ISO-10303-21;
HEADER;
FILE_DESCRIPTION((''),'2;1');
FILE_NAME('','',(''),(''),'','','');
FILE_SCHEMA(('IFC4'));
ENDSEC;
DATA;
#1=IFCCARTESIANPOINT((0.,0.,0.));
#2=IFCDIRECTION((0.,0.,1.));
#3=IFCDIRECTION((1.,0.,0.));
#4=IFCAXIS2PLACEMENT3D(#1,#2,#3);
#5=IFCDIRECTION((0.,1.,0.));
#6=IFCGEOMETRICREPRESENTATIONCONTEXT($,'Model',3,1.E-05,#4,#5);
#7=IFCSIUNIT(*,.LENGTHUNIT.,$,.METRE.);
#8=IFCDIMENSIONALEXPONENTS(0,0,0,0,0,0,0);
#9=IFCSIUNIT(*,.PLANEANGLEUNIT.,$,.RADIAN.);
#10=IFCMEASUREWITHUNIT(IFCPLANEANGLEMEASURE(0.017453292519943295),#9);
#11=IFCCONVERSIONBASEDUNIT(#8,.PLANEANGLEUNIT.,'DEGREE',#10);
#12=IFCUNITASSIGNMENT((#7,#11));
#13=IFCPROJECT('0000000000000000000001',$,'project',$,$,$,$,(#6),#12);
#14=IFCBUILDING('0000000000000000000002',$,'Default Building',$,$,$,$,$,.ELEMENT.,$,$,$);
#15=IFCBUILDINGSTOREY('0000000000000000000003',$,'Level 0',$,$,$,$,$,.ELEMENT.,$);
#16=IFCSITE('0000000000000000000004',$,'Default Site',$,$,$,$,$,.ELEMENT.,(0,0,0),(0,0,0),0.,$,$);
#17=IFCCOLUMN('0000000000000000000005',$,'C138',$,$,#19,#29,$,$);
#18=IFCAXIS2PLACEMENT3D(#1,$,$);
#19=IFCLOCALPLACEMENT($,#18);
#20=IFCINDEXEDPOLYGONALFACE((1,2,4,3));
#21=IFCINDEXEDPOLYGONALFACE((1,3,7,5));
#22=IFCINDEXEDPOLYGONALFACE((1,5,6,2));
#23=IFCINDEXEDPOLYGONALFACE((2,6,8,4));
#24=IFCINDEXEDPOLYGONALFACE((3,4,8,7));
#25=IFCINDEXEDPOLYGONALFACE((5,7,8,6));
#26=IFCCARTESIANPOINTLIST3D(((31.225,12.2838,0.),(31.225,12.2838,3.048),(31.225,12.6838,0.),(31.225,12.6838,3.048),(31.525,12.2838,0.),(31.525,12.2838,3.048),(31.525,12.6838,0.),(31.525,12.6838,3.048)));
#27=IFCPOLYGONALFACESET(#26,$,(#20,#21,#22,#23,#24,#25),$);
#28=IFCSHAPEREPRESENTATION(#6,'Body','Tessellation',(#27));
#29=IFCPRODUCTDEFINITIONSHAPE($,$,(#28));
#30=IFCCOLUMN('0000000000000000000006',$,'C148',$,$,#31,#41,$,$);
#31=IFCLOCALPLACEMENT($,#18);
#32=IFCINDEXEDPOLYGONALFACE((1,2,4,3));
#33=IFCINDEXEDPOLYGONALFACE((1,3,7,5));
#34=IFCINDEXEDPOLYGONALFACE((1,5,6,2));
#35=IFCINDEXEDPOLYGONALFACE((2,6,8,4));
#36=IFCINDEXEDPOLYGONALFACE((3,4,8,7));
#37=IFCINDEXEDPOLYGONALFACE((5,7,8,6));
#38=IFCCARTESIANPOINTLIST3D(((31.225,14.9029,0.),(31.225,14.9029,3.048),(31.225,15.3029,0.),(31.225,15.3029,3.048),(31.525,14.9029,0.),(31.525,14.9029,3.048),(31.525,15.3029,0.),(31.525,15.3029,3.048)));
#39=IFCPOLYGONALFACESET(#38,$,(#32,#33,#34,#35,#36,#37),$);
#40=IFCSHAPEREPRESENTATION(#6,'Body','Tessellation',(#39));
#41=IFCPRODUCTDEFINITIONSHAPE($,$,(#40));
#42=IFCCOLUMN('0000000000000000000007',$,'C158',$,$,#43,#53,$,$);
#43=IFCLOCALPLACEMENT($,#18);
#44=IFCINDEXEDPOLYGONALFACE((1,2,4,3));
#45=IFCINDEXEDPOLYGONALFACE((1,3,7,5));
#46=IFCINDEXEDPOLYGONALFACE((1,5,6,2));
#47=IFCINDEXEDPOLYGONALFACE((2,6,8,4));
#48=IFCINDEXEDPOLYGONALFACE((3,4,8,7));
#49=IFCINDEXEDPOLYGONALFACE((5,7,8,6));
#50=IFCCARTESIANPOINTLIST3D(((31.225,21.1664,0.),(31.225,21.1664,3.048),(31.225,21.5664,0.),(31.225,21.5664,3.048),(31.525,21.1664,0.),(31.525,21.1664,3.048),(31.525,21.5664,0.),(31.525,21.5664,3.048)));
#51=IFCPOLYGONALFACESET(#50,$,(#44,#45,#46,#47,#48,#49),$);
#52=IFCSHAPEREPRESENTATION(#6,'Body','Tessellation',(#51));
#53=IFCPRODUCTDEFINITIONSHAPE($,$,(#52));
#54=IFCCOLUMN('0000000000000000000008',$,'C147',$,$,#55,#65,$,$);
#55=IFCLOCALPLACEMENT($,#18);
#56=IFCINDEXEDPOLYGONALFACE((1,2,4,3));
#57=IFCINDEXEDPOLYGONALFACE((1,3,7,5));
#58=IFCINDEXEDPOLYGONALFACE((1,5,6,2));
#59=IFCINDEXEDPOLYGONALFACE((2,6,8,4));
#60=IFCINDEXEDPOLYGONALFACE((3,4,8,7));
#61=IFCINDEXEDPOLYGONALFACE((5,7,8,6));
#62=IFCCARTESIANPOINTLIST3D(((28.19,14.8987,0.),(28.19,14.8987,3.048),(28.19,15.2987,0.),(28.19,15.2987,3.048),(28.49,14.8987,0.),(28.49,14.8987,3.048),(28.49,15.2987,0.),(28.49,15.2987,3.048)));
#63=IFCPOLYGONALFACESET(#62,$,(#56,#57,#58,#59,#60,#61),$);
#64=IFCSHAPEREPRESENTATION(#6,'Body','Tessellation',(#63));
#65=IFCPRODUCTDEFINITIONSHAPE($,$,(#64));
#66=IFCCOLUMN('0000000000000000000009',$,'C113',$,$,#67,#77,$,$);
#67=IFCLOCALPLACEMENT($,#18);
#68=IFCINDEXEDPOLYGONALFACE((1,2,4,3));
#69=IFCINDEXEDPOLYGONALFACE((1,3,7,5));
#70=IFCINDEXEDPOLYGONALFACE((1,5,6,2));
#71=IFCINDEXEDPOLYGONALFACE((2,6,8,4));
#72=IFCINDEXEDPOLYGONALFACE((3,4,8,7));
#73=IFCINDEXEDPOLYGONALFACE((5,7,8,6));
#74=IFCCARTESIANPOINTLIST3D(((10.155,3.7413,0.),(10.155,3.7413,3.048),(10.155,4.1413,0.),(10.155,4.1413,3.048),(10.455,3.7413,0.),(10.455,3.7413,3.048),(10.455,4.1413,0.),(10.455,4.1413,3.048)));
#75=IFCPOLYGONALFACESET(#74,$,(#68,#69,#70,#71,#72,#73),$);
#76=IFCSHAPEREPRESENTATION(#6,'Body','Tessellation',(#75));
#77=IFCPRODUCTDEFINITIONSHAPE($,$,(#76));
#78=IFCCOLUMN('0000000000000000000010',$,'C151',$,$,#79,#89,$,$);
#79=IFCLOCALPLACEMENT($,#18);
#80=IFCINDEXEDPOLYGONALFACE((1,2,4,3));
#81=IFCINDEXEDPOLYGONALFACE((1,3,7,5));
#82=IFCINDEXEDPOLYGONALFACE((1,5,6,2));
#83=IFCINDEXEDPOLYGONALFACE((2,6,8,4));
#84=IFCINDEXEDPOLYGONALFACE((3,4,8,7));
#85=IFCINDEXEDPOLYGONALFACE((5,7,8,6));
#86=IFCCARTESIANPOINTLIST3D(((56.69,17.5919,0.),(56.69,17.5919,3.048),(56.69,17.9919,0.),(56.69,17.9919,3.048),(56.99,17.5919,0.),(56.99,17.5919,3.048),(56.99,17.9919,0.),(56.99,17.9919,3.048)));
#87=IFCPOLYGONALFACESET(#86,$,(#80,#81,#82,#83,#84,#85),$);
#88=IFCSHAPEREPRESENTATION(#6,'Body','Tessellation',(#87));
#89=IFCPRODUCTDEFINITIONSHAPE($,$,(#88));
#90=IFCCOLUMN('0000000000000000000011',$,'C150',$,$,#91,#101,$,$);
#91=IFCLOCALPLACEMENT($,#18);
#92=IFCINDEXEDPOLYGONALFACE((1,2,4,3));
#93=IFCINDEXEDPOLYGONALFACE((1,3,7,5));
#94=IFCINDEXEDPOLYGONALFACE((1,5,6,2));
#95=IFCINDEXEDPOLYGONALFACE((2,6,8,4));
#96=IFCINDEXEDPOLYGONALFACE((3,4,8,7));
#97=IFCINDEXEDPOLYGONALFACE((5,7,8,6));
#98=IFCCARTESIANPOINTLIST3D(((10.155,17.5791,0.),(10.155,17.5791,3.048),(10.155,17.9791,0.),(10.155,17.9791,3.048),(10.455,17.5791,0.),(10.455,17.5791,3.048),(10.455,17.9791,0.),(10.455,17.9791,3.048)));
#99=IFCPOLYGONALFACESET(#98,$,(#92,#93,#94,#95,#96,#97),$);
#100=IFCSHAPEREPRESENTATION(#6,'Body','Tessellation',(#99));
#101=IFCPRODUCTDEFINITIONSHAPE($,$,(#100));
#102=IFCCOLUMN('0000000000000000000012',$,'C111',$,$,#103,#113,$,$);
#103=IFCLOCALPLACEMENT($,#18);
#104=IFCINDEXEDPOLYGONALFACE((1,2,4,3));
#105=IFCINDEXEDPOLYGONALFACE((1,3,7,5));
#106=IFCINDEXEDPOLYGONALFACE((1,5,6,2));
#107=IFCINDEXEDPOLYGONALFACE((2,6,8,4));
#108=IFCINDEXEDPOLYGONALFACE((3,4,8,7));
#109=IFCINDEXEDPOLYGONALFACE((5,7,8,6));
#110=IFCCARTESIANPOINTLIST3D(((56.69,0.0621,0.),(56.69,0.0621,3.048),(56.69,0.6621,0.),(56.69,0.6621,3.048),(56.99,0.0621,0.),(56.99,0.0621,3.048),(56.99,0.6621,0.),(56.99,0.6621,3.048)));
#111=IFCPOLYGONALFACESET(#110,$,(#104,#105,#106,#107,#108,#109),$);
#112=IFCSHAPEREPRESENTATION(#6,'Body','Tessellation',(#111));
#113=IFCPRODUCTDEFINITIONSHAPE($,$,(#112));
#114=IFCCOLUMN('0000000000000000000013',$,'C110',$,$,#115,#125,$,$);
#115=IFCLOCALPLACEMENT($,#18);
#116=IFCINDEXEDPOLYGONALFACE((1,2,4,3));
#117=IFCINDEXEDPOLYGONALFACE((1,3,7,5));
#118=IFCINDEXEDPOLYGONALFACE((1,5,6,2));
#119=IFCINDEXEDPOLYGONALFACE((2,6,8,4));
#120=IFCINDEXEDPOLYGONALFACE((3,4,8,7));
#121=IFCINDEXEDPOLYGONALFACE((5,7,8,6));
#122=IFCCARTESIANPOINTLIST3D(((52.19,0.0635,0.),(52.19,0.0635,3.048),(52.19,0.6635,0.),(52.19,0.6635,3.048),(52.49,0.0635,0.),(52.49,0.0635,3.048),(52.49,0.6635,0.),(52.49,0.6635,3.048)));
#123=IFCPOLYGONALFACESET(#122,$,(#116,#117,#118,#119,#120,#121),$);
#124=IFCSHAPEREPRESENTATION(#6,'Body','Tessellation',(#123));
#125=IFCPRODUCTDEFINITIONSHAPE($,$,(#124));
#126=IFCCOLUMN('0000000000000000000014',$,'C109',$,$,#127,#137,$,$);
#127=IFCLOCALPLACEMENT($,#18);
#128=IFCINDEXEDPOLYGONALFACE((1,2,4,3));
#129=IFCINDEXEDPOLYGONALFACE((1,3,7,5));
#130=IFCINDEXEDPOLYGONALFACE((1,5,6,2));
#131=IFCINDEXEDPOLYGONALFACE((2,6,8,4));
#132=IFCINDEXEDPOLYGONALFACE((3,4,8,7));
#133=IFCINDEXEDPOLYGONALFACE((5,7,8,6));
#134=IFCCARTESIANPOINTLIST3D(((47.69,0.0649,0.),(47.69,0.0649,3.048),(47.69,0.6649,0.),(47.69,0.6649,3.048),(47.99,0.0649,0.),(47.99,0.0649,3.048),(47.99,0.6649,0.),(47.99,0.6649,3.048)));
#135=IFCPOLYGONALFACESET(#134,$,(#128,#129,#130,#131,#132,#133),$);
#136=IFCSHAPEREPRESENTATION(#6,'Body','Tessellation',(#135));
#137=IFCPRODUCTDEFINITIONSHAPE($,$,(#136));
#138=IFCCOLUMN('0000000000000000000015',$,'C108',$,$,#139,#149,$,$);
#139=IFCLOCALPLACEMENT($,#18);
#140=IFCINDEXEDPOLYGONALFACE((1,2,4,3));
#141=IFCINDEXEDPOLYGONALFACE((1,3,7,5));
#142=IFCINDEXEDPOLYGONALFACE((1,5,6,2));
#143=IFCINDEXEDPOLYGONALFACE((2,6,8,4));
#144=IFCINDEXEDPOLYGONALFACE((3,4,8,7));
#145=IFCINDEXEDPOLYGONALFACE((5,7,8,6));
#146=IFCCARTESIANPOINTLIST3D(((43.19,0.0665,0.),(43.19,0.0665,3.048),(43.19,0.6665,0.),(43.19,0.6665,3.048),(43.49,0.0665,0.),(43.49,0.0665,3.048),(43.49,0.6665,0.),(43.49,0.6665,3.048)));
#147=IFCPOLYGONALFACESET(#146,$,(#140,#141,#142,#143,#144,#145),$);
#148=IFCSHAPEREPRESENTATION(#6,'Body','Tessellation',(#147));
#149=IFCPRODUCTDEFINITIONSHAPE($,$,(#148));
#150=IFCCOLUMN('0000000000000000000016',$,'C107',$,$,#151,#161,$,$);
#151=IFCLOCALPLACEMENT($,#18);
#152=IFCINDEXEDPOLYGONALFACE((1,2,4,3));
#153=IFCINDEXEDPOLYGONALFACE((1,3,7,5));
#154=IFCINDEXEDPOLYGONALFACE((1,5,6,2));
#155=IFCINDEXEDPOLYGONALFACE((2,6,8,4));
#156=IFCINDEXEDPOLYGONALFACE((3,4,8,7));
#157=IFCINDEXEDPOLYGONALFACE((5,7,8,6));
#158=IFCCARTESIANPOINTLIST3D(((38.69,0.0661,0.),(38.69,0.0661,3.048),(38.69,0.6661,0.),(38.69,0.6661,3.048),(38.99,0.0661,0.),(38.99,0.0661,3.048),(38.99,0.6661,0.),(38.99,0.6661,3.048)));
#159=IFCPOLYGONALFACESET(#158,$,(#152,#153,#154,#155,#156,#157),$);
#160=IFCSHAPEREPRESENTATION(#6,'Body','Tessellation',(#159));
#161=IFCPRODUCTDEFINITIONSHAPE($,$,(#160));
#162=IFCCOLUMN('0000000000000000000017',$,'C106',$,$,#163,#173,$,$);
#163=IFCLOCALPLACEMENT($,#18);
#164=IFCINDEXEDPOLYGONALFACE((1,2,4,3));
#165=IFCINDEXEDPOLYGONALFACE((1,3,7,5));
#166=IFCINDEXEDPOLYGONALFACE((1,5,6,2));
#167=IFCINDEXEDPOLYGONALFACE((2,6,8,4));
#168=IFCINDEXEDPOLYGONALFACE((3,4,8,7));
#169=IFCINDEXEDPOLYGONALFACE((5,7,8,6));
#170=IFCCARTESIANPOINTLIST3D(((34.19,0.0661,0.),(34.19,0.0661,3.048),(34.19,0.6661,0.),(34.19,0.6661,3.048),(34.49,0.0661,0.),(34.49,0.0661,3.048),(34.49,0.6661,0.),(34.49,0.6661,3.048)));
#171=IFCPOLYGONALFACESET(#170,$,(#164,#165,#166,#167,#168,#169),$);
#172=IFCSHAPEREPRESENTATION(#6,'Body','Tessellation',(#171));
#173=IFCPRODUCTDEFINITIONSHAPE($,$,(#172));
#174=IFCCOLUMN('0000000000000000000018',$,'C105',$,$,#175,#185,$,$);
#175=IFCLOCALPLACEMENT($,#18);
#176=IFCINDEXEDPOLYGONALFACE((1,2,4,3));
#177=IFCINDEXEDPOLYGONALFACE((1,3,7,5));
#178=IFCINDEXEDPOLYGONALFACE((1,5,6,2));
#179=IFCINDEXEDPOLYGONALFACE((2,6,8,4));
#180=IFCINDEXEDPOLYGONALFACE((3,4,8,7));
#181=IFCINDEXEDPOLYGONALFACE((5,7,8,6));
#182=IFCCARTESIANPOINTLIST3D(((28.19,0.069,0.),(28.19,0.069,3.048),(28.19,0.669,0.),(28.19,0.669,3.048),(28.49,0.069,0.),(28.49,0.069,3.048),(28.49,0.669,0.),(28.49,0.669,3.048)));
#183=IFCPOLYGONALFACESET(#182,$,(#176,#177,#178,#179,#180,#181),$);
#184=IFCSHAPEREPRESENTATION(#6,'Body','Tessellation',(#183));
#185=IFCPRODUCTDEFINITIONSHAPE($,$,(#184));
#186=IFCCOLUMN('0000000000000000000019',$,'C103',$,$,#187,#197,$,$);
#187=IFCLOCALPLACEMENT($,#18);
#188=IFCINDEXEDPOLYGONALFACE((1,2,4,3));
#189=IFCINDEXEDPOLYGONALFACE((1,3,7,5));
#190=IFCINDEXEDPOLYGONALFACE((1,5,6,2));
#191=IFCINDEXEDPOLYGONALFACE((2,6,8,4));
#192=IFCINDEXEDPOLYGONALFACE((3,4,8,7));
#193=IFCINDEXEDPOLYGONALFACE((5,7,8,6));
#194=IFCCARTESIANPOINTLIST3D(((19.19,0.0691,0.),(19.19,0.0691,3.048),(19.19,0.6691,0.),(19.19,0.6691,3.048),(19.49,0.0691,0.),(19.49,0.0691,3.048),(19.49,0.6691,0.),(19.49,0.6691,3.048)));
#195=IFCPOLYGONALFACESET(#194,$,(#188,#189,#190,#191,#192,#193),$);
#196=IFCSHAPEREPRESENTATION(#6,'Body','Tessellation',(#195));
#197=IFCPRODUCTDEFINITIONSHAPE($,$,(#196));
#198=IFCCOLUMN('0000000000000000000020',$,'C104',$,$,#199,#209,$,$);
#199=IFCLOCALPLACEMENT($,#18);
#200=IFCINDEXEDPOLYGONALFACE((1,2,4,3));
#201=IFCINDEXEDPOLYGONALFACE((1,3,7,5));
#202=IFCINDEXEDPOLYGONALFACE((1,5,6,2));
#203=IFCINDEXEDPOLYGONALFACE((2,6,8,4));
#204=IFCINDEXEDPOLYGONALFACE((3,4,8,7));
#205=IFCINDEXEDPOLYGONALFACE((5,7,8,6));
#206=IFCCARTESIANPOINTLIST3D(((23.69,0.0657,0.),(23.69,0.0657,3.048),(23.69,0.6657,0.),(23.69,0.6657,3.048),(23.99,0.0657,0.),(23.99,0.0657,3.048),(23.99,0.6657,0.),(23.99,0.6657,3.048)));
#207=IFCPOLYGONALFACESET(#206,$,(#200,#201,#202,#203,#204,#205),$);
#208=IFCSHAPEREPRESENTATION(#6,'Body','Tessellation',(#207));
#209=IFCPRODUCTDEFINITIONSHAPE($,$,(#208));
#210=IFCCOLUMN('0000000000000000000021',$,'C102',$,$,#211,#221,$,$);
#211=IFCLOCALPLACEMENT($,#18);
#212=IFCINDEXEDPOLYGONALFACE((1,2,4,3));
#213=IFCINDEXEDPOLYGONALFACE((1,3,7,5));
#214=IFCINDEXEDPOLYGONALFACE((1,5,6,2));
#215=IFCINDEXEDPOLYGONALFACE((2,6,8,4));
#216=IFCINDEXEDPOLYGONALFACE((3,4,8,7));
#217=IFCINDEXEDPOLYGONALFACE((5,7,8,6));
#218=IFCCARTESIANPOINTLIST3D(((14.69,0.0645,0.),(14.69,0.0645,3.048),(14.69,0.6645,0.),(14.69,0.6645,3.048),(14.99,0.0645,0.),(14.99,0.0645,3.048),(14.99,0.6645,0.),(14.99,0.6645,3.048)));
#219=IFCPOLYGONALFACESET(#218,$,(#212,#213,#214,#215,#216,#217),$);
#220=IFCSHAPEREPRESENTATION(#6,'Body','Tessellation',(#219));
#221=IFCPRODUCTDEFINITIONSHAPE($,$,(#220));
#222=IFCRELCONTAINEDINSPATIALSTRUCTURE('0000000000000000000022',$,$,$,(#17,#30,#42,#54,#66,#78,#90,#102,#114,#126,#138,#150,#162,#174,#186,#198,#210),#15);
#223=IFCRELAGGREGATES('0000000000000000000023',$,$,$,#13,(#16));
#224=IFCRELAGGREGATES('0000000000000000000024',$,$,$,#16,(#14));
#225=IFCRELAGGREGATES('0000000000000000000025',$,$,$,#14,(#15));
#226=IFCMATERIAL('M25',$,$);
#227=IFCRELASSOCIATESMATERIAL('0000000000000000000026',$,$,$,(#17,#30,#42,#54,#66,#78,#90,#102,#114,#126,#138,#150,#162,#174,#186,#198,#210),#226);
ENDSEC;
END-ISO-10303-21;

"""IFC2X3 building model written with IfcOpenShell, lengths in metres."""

from ifc_helpers import new_model, entity, si_unit, converted_unit, direction, frame, frame_2d, origin_with_axes, place, context, project, spatial, rectangle, extrude, material, element, save


model = new_model("IFC2X3")

# Units and contexts
model_context = context("Model", 3, precision=1e-05, world=origin_with_axes(), true_north=direction((0.0, 1.0, 0.0)))
ifc_project = project(units=[si_unit("LENGTHUNIT", "METRE"), converted_unit("PLANEANGLEUNIT", "DEGREE", entity("IfcPlaneAngleMeasure", 0.017453292519943295), si_unit("PLANEANGLEUNIT", "RADIAN"), dimensions=[0, 0, 0, 0, 0, 0, 0])], contexts=[model_context])

# Site, building, storey
site = spatial("IfcSite", under=ifc_project, Name="Default Site", CompositionType="ELEMENT", RefLatitude=(0, 0, 0), RefLongitude=(0, 0, 0), RefElevation=0.0)
building = spatial("IfcBuilding", under=site, Name="Default Building", CompositionType="ELEMENT")
storey = spatial("IfcBuildingStorey", under=building, Name="Level 0", CompositionType="ELEMENT")

# Columns
ifc_material = material(Name="M25")
placement = place(None, origin_with_axes())
element("IfcColumn", 1, at=placement, inside=storey, material=ifc_material, Name="C138", context=model_context, shape_type="SweptSolid", body=[
    extrude(rectangle(XDim=0.3, YDim=0.4, at=frame_2d((0.0, 0.0), x_axis=(1.0, 0.0, 0.0))), frame((31.375, 12.4838, 0.0), z_axis=(0.0, 0.0, 1.0), x_axis=(1.0, 0.0, 0.0)), (0.0, 0.0, 1.0), 3.048),
])
element("IfcColumn", 2, at=placement, inside=storey, material=ifc_material, Name="C148", context=model_context, shape_type="SweptSolid", body=[
    extrude(rectangle(XDim=0.3, YDim=0.4, at=frame_2d((0.0, 0.0), x_axis=(1.0, 0.0, 0.0))), frame((31.375, 15.1029, 0.0), z_axis=(0.0, 0.0, 1.0), x_axis=(1.0, 0.0, 0.0)), (0.0, 0.0, 1.0), 3.048),
])
element("IfcColumn", 3, at=placement, inside=storey, material=ifc_material, Name="C158", context=model_context, shape_type="SweptSolid", body=[
    extrude(rectangle(XDim=0.3, YDim=0.4, at=frame_2d((0.0, 0.0), x_axis=(1.0, 0.0, 0.0))), frame((31.375, 21.3664, 0.0), z_axis=(0.0, 0.0, 1.0), x_axis=(1.0, 0.0, 0.0)), (0.0, 0.0, 1.0), 3.048),
])
element("IfcColumn", 4, at=placement, inside=storey, material=ifc_material, Name="C147", context=model_context, shape_type="SweptSolid", body=[
    extrude(rectangle(XDim=0.3, YDim=0.4, at=frame_2d((0.0, 0.0), x_axis=(1.0, 0.0, 0.0))), frame((28.34, 15.0987, 0.0), z_axis=(0.0, 0.0, 1.0), x_axis=(1.0, 0.0, 0.0)), (0.0, 0.0, 1.0), 3.048),
])
element("IfcColumn", 5, at=placement, inside=storey, material=ifc_material, Name="C113", context=model_context, shape_type="SweptSolid", body=[
    extrude(rectangle(XDim=0.3, YDim=0.4, at=frame_2d((0.0, 0.0), x_axis=(1.0, 0.0, 0.0))), frame((10.305, 3.9413, 0.0), z_axis=(0.0, 0.0, 1.0), x_axis=(1.0, 0.0, 0.0)), (0.0, 0.0, 1.0), 3.048),
])
element("IfcColumn", 6, at=placement, inside=storey, material=ifc_material, Name="C151", context=model_context, shape_type="SweptSolid", body=[
    extrude(rectangle(XDim=0.3, YDim=0.4, at=frame_2d((0.0, 0.0), x_axis=(1.0, 0.0, 0.0))), frame((56.84, 17.7919, 0.0), z_axis=(0.0, 0.0, 1.0), x_axis=(1.0, 0.0, 0.0)), (0.0, 0.0, 1.0), 3.048),
])
element("IfcColumn", 7, at=placement, inside=storey, material=ifc_material, Name="C150", context=model_context, shape_type="SweptSolid", body=[
    extrude(rectangle(XDim=0.3, YDim=0.4, at=frame_2d((0.0, 0.0), x_axis=(1.0, 0.0, 0.0))), frame((10.305, 17.7791, 0.0), z_axis=(0.0, 0.0, 1.0), x_axis=(1.0, 0.0, 0.0)), (0.0, 0.0, 1.0), 3.048),
])
element("IfcColumn", 8, at=placement, inside=storey, material=ifc_material, Name="C111", context=model_context, shape_type="SweptSolid", body=[
    extrude(rectangle(XDim=0.3, YDim=0.6, at=frame_2d((0.0, 0.0), x_axis=(1.0, 0.0, 0.0))), frame((56.84, 0.3621, 0.0), z_axis=(0.0, 0.0, 1.0), x_axis=(1.0, 0.0, 0.0)), (0.0, 0.0, 1.0), 3.048),
])
element("IfcColumn", 9, at=placement, inside=storey, material=ifc_material, Name="C110", context=model_context, shape_type="SweptSolid", body=[
    extrude(rectangle(XDim=0.3, YDim=0.6, at=frame_2d((0.0, 0.0), x_axis=(1.0, 0.0, 0.0))), frame((52.34, 0.3635, 0.0), z_axis=(0.0, 0.0, 1.0), x_axis=(1.0, 0.0, 0.0)), (0.0, 0.0, 1.0), 3.048),
])
element("IfcColumn", 10, at=placement, inside=storey, material=ifc_material, Name="C109", context=model_context, shape_type="SweptSolid", body=[
    extrude(rectangle(XDim=0.3, YDim=0.6, at=frame_2d((0.0, 0.0), x_axis=(1.0, 0.0, 0.0))), frame((47.84, 0.3649, 0.0), z_axis=(0.0, 0.0, 1.0), x_axis=(1.0, 0.0, 0.0)), (0.0, 0.0, 1.0), 3.048),
])
element("IfcColumn", 11, at=placement, inside=storey, material=ifc_material, Name="C108", context=model_context, shape_type="SweptSolid", body=[
    extrude(rectangle(XDim=0.3, YDim=0.6, at=frame_2d((0.0, 0.0), x_axis=(1.0, 0.0, 0.0))), frame((43.34, 0.3665, 0.0), z_axis=(0.0, 0.0, 1.0), x_axis=(1.0, 0.0, 0.0)), (0.0, 0.0, 1.0), 3.048),
])
element("IfcColumn", 12, at=placement, inside=storey, material=ifc_material, Name="C107", context=model_context, shape_type="SweptSolid", body=[
    extrude(rectangle(XDim=0.3, YDim=0.6, at=frame_2d((0.0, 0.0), x_axis=(1.0, 0.0, 0.0))), frame((38.84, 0.3661, 0.0), z_axis=(0.0, 0.0, 1.0), x_axis=(1.0, 0.0, 0.0)), (0.0, 0.0, 1.0), 3.048),
])
element("IfcColumn", 13, at=placement, inside=storey, material=ifc_material, Name="C106", context=model_context, shape_type="SweptSolid", body=[
    extrude(rectangle(XDim=0.3, YDim=0.6, at=frame_2d((0.0, 0.0), x_axis=(1.0, 0.0, 0.0))), frame((34.34, 0.3661, 0.0), z_axis=(0.0, 0.0, 1.0), x_axis=(1.0, 0.0, 0.0)), (0.0, 0.0, 1.0), 3.048),
])
element("IfcColumn", 14, at=placement, inside=storey, material=ifc_material, Name="C105", context=model_context, shape_type="SweptSolid", body=[
    extrude(rectangle(XDim=0.3, YDim=0.6, at=frame_2d((0.0, 0.0), x_axis=(1.0, 0.0, 0.0))), frame((28.34, 0.369, 0.0), z_axis=(0.0, 0.0, 1.0), x_axis=(1.0, 0.0, 0.0)), (0.0, 0.0, 1.0), 3.048),
])
element("IfcColumn", 15, at=placement, inside=storey, material=ifc_material, Name="C103", context=model_context, shape_type="SweptSolid", body=[
    extrude(rectangle(XDim=0.3, YDim=0.6, at=frame_2d((0.0, 0.0), x_axis=(1.0, 0.0, 0.0))), frame((19.34, 0.3691, 0.0), z_axis=(0.0, 0.0, 1.0), x_axis=(1.0, 0.0, 0.0)), (0.0, 0.0, 1.0), 3.048),
])
element("IfcColumn", 16, at=placement, inside=storey, material=ifc_material, Name="C104", context=model_context, shape_type="SweptSolid", body=[
    extrude(rectangle(XDim=0.3, YDim=0.6, at=frame_2d((0.0, 0.0), x_axis=(1.0, 0.0, 0.0))), frame((23.84, 0.3657, 0.0), z_axis=(0.0, 0.0, 1.0), x_axis=(1.0, 0.0, 0.0)), (0.0, 0.0, 1.0), 3.048),
])
element("IfcColumn", 17, at=placement, inside=storey, material=ifc_material, Name="C102", context=model_context, shape_type="SweptSolid", body=[
    extrude(rectangle(XDim=0.3, YDim=0.6, at=frame_2d((0.0, 0.0), x_axis=(1.0, 0.0, 0.0))), frame((14.84, 0.3645, 0.0), z_axis=(0.0, 0.0, 1.0), x_axis=(1.0, 0.0, 0.0)), (0.0, 0.0, 1.0), 3.048),
])

save(model, "model.ifc")
